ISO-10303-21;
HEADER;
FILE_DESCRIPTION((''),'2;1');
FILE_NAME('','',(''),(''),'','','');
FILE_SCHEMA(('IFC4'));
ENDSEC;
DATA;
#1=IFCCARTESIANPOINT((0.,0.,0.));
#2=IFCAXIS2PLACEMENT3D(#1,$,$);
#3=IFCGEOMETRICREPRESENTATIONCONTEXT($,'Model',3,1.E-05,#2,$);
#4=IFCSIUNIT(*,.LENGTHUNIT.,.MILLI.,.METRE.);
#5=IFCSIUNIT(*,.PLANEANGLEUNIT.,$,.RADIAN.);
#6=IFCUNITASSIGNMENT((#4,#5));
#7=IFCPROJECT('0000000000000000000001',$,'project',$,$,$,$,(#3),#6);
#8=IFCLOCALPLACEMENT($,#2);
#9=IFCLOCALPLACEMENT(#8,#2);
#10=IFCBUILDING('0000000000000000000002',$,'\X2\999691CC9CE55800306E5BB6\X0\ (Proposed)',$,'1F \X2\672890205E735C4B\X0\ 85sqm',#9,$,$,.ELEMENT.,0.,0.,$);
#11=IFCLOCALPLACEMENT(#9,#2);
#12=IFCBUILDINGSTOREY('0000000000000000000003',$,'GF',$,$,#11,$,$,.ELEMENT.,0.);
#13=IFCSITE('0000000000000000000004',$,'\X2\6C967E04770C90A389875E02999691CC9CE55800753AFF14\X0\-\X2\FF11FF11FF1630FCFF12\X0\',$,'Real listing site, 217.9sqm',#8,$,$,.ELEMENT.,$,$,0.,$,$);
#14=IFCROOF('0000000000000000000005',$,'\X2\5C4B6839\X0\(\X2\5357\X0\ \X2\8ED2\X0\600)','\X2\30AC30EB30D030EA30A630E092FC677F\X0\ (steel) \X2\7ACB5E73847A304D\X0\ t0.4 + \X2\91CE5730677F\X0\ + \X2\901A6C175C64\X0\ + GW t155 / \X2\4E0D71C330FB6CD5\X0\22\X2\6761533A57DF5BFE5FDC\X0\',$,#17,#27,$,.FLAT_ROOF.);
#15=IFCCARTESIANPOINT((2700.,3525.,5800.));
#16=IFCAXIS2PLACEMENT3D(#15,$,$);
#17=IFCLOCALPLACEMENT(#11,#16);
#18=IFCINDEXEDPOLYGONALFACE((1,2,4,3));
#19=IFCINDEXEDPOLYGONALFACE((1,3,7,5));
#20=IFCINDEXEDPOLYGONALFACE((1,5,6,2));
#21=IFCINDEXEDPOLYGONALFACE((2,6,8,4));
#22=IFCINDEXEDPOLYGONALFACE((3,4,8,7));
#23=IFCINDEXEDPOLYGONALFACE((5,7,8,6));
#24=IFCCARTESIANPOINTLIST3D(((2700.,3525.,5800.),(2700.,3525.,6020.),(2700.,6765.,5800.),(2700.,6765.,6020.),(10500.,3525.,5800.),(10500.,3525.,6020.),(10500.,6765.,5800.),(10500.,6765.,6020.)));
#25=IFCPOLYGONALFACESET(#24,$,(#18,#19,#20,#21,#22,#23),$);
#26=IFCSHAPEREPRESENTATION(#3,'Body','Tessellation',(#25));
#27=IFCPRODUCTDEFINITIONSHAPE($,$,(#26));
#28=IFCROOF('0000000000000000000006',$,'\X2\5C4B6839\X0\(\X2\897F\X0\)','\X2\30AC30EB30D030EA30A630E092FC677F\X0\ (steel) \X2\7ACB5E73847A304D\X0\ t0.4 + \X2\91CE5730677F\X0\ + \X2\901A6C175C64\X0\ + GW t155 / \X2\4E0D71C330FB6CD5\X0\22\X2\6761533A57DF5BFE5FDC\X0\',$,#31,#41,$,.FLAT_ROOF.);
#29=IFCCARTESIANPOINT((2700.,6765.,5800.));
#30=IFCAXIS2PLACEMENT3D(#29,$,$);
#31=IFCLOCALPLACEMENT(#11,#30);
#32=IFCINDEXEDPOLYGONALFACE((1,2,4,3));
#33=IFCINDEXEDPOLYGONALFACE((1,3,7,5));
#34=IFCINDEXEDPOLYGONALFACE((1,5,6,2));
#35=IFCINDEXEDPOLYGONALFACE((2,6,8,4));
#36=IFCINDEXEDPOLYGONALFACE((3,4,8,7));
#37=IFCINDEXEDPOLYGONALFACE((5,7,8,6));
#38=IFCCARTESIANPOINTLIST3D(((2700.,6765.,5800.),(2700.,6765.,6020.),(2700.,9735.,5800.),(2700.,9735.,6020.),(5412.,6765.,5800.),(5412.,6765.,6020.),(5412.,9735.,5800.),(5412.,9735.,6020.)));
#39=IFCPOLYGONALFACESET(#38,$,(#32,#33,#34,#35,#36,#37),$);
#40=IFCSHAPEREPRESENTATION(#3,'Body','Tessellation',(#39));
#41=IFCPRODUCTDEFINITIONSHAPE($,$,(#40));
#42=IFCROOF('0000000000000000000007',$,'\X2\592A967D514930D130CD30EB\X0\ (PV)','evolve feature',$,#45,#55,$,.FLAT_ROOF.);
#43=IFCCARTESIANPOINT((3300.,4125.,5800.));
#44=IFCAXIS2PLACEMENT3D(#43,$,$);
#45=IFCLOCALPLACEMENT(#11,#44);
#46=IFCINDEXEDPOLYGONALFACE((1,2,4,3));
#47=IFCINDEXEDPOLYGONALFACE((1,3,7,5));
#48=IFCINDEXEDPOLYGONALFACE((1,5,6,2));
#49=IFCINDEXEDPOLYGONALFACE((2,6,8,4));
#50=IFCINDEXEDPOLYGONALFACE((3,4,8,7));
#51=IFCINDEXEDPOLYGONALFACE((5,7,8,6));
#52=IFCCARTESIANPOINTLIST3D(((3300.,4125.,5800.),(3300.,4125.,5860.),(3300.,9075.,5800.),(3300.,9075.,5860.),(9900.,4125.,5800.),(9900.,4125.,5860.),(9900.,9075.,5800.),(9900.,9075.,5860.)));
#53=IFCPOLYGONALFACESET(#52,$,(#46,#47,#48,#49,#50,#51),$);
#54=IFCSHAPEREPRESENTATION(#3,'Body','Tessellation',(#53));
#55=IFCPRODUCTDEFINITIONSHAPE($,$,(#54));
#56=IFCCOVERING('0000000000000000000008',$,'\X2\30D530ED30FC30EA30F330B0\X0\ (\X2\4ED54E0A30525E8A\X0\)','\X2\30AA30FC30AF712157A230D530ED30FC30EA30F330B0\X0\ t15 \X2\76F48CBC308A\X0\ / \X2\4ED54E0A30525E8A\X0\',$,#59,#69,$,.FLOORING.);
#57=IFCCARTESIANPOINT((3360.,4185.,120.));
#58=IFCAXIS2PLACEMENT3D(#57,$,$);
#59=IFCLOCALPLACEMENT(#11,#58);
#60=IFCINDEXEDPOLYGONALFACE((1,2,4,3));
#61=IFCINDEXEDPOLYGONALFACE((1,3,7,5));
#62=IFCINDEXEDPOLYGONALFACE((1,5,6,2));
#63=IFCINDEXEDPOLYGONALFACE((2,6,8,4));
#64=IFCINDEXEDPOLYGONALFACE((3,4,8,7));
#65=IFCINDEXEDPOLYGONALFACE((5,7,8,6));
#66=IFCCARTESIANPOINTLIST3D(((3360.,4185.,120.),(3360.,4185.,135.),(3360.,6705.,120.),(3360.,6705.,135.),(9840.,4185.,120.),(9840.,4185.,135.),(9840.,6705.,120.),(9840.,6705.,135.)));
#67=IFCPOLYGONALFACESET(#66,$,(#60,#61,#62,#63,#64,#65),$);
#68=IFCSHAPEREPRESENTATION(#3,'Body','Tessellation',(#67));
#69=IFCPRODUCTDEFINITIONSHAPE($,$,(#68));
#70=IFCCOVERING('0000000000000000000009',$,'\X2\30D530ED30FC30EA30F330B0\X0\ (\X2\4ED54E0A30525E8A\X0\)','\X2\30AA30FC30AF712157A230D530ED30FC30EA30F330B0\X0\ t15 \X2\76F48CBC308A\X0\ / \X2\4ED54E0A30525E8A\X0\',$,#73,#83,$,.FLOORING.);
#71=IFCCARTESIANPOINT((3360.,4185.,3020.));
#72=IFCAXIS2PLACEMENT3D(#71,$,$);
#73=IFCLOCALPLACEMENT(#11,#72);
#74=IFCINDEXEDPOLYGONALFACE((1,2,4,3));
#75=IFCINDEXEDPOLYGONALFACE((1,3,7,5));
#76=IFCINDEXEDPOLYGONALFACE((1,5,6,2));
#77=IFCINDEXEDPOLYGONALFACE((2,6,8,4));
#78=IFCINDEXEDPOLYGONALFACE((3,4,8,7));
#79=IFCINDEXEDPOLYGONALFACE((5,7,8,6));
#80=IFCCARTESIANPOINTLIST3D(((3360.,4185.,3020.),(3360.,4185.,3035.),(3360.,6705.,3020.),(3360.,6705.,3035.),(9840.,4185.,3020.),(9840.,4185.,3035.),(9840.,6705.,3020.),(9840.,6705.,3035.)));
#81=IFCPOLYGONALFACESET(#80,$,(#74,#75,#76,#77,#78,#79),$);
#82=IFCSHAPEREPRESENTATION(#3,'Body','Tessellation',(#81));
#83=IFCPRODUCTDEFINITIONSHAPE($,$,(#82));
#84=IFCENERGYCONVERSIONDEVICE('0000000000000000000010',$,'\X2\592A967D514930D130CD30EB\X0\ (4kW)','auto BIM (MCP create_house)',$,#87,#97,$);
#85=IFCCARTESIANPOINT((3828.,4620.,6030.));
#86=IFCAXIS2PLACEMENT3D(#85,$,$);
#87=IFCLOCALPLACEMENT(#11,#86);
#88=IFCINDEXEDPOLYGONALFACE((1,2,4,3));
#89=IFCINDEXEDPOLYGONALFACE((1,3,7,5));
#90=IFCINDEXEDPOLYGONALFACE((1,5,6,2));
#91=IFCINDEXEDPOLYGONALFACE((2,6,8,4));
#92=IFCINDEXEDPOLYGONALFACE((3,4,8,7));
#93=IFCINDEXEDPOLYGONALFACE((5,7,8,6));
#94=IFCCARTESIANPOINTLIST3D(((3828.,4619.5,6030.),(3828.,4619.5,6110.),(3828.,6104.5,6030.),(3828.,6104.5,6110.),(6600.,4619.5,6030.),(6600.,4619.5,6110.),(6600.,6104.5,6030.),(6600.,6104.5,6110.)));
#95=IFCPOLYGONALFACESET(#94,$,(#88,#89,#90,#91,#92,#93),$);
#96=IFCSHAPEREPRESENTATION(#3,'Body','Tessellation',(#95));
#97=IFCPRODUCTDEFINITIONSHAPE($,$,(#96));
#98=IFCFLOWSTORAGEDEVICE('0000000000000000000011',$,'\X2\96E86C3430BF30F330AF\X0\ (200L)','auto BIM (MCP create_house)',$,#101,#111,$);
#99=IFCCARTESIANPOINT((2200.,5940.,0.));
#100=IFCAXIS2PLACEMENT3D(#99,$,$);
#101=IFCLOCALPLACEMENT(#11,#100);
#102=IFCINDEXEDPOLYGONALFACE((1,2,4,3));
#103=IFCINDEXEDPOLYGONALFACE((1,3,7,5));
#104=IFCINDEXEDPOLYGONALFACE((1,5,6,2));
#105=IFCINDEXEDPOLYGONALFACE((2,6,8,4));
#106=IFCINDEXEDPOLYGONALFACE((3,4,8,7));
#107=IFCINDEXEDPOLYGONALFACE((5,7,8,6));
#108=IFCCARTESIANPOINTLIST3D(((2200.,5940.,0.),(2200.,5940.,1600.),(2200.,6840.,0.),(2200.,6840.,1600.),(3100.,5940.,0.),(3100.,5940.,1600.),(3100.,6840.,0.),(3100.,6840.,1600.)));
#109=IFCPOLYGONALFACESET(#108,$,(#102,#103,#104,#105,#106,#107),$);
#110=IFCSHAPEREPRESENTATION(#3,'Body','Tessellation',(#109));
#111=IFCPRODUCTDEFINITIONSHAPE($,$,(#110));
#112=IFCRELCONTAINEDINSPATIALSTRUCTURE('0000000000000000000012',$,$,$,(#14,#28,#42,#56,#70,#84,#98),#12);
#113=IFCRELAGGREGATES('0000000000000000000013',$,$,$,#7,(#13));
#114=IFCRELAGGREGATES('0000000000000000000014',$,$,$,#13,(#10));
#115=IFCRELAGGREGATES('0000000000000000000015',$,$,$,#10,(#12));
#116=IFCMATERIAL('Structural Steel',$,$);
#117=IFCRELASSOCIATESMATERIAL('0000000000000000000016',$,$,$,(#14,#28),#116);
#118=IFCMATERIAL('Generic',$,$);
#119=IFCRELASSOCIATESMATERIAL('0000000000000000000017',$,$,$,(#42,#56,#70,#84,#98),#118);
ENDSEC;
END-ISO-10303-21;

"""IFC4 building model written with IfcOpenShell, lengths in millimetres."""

from ifc_helpers import new_model, si_unit, frame, frame_2d, origin, place, context, project, spatial, rectangle, extrude, material, element, save


model = new_model("IFC4")

# Units and contexts
model_context = context("Model", 3, precision=1e-05, world=origin())
ifc_project = project(units=[si_unit("LENGTHUNIT", "METRE", prefix="MILLI"), si_unit("PLANEANGLEUNIT", "RADIAN")], contexts=[model_context])

# Site, building, storey
site_placement = place(None, origin())
site = spatial("IfcSite", under=ifc_project, at=site_placement, Name="沖縄県那覇市首里鳥堀町４-１１６ー２", ObjectType="Real listing site, 217.9sqm", CompositionType="ELEMENT", RefElevation=0.0)
building_placement = place(site_placement, origin())
building = spatial("IfcBuilding", under=site, at=building_placement, Name="首里鳥堀の家 (Proposed)", ObjectType="1F 木造平屋 85sqm", CompositionType="ELEMENT", ElevationOfRefHeight=0.0, ElevationOfTerrain=0.0)
storey_placement = place(building_placement, origin())
storey = spatial("IfcBuildingStorey", under=building, at=storey_placement, Name="GF", CompositionType="ELEMENT", Elevation=0.0)

# Shared definitions
ifc_material_1 = material(Name="Generic")

# Roofs
ifc_material_2 = material(Name="Structural Steel")
roof_1_placement = place(storey_placement, frame((2700.0, 3525.0, 5800.0)))
element("IfcRoof", 1, at=roof_1_placement, inside=storey, material=ifc_material_2, Name="屋根(南 軒600)", Description="ガルバリウム鋼板 (steel) 立平葺き t0.4 + 野地板 + 通気層 + GW t155 / 不燃・法22条区域対応", PredefinedType="FLAT_ROOF", context=model_context, shape_type="SweptSolid", body=[
    extrude(rectangle(XDim=7800.0, YDim=3240.0, at=frame_2d((3900.0, 1620.0))), frame((2700.0, 3525.0, 5800.0)), (0.0, 0.0, 1.0), 220.0),
])
roof_2_placement = place(storey_placement, frame((2700.0, 6765.0, 5800.0)))
element("IfcRoof", 2, at=roof_2_placement, inside=storey, material=ifc_material_2, Name="屋根(西)", Description="ガルバリウム鋼板 (steel) 立平葺き t0.4 + 野地板 + 通気層 + GW t155 / 不燃・法22条区域対応", PredefinedType="FLAT_ROOF", context=model_context, shape_type="SweptSolid", body=[
    extrude(rectangle(XDim=2712.0, YDim=2970.0, at=frame_2d((1356.0, 1485.0))), frame((2700.0, 6765.0, 5800.0)), (0.0, 0.0, 1.0), 220.0),
])
roof_3_placement = place(storey_placement, frame((3300.0, 4125.0, 5800.0)))
element("IfcRoof", 3, at=roof_3_placement, inside=storey, material=ifc_material_1, Name="太陽光パネル (PV)", Description="evolve feature", PredefinedType="FLAT_ROOF", context=model_context, shape_type="SweptSolid", body=[
    extrude(rectangle(XDim=6600.0, YDim=4950.0, at=frame_2d((3300.0, 2475.0))), frame((3300.0, 4125.0, 5800.0)), (0.0, 0.0, 1.0), 60.0),
])

# Coverings
covering_1_placement = place(storey_placement, frame((3360.0, 4185.0, 120.0)))
element("IfcCovering", 4, at=covering_1_placement, inside=storey, material=ifc_material_1, Name="フローリング (仕上げ床)", Description="オーク無垢フローリング t15 直貼り / 仕上げ床", PredefinedType="FLOORING", context=model_context, shape_type="SweptSolid", body=[
    extrude(rectangle(XDim=6480.0, YDim=2520.0, at=frame_2d((3240.0, 1260.0))), frame((3360.0, 4185.0, 120.0)), (0.0, 0.0, 1.0), 15.0),
])
covering_2_placement = place(storey_placement, frame((3360.0, 4185.0, 3020.0)))
element("IfcCovering", 5, at=covering_2_placement, inside=storey, material=ifc_material_1, Name="フローリング (仕上げ床)", Description="オーク無垢フローリング t15 直貼り / 仕上げ床", PredefinedType="FLOORING", context=model_context, shape_type="SweptSolid", body=[
    extrude(rectangle(XDim=6480.0, YDim=2520.0, at=frame_2d((3240.0, 1260.0))), frame((3360.0, 4185.0, 3020.0)), (0.0, 0.0, 1.0), 15.0),
])

# Energy conversion device
energy_conversion_device_placement = place(storey_placement, frame((3828.0, 4620.0, 6030.0)))
element("IfcEnergyConversionDevice", 6, at=energy_conversion_device_placement, inside=storey, material=ifc_material_1, Name="太陽光パネル (4kW)", Description="auto BIM (MCP create_house)", context=model_context, shape_type="SweptSolid", body=[
    extrude(rectangle(XDim=2772.0, YDim=1485.0, at=frame_2d((1386.0, 742.0))), frame((3828.0, 4620.0, 6030.0)), (0.0, 0.0, 1.0), 80.0),
])

# Flow storage device
flow_storage_device_placement = place(storey_placement, frame((2200.0, 5940.0, 0.0)))
element("IfcFlowStorageDevice", 7, at=flow_storage_device_placement, inside=storey, material=ifc_material_1, Name="雨水タンク (200L)", Description="auto BIM (MCP create_house)", context=model_context, shape_type="SweptSolid", body=[
    extrude(rectangle(XDim=900.0, YDim=900.0, at=frame_2d((450.0, 450.0))), frame((2200.0, 5940.0, 0.0)), (0.0, 0.0, 1.0), 1600.0),
])

save(model, "model.ifc")
